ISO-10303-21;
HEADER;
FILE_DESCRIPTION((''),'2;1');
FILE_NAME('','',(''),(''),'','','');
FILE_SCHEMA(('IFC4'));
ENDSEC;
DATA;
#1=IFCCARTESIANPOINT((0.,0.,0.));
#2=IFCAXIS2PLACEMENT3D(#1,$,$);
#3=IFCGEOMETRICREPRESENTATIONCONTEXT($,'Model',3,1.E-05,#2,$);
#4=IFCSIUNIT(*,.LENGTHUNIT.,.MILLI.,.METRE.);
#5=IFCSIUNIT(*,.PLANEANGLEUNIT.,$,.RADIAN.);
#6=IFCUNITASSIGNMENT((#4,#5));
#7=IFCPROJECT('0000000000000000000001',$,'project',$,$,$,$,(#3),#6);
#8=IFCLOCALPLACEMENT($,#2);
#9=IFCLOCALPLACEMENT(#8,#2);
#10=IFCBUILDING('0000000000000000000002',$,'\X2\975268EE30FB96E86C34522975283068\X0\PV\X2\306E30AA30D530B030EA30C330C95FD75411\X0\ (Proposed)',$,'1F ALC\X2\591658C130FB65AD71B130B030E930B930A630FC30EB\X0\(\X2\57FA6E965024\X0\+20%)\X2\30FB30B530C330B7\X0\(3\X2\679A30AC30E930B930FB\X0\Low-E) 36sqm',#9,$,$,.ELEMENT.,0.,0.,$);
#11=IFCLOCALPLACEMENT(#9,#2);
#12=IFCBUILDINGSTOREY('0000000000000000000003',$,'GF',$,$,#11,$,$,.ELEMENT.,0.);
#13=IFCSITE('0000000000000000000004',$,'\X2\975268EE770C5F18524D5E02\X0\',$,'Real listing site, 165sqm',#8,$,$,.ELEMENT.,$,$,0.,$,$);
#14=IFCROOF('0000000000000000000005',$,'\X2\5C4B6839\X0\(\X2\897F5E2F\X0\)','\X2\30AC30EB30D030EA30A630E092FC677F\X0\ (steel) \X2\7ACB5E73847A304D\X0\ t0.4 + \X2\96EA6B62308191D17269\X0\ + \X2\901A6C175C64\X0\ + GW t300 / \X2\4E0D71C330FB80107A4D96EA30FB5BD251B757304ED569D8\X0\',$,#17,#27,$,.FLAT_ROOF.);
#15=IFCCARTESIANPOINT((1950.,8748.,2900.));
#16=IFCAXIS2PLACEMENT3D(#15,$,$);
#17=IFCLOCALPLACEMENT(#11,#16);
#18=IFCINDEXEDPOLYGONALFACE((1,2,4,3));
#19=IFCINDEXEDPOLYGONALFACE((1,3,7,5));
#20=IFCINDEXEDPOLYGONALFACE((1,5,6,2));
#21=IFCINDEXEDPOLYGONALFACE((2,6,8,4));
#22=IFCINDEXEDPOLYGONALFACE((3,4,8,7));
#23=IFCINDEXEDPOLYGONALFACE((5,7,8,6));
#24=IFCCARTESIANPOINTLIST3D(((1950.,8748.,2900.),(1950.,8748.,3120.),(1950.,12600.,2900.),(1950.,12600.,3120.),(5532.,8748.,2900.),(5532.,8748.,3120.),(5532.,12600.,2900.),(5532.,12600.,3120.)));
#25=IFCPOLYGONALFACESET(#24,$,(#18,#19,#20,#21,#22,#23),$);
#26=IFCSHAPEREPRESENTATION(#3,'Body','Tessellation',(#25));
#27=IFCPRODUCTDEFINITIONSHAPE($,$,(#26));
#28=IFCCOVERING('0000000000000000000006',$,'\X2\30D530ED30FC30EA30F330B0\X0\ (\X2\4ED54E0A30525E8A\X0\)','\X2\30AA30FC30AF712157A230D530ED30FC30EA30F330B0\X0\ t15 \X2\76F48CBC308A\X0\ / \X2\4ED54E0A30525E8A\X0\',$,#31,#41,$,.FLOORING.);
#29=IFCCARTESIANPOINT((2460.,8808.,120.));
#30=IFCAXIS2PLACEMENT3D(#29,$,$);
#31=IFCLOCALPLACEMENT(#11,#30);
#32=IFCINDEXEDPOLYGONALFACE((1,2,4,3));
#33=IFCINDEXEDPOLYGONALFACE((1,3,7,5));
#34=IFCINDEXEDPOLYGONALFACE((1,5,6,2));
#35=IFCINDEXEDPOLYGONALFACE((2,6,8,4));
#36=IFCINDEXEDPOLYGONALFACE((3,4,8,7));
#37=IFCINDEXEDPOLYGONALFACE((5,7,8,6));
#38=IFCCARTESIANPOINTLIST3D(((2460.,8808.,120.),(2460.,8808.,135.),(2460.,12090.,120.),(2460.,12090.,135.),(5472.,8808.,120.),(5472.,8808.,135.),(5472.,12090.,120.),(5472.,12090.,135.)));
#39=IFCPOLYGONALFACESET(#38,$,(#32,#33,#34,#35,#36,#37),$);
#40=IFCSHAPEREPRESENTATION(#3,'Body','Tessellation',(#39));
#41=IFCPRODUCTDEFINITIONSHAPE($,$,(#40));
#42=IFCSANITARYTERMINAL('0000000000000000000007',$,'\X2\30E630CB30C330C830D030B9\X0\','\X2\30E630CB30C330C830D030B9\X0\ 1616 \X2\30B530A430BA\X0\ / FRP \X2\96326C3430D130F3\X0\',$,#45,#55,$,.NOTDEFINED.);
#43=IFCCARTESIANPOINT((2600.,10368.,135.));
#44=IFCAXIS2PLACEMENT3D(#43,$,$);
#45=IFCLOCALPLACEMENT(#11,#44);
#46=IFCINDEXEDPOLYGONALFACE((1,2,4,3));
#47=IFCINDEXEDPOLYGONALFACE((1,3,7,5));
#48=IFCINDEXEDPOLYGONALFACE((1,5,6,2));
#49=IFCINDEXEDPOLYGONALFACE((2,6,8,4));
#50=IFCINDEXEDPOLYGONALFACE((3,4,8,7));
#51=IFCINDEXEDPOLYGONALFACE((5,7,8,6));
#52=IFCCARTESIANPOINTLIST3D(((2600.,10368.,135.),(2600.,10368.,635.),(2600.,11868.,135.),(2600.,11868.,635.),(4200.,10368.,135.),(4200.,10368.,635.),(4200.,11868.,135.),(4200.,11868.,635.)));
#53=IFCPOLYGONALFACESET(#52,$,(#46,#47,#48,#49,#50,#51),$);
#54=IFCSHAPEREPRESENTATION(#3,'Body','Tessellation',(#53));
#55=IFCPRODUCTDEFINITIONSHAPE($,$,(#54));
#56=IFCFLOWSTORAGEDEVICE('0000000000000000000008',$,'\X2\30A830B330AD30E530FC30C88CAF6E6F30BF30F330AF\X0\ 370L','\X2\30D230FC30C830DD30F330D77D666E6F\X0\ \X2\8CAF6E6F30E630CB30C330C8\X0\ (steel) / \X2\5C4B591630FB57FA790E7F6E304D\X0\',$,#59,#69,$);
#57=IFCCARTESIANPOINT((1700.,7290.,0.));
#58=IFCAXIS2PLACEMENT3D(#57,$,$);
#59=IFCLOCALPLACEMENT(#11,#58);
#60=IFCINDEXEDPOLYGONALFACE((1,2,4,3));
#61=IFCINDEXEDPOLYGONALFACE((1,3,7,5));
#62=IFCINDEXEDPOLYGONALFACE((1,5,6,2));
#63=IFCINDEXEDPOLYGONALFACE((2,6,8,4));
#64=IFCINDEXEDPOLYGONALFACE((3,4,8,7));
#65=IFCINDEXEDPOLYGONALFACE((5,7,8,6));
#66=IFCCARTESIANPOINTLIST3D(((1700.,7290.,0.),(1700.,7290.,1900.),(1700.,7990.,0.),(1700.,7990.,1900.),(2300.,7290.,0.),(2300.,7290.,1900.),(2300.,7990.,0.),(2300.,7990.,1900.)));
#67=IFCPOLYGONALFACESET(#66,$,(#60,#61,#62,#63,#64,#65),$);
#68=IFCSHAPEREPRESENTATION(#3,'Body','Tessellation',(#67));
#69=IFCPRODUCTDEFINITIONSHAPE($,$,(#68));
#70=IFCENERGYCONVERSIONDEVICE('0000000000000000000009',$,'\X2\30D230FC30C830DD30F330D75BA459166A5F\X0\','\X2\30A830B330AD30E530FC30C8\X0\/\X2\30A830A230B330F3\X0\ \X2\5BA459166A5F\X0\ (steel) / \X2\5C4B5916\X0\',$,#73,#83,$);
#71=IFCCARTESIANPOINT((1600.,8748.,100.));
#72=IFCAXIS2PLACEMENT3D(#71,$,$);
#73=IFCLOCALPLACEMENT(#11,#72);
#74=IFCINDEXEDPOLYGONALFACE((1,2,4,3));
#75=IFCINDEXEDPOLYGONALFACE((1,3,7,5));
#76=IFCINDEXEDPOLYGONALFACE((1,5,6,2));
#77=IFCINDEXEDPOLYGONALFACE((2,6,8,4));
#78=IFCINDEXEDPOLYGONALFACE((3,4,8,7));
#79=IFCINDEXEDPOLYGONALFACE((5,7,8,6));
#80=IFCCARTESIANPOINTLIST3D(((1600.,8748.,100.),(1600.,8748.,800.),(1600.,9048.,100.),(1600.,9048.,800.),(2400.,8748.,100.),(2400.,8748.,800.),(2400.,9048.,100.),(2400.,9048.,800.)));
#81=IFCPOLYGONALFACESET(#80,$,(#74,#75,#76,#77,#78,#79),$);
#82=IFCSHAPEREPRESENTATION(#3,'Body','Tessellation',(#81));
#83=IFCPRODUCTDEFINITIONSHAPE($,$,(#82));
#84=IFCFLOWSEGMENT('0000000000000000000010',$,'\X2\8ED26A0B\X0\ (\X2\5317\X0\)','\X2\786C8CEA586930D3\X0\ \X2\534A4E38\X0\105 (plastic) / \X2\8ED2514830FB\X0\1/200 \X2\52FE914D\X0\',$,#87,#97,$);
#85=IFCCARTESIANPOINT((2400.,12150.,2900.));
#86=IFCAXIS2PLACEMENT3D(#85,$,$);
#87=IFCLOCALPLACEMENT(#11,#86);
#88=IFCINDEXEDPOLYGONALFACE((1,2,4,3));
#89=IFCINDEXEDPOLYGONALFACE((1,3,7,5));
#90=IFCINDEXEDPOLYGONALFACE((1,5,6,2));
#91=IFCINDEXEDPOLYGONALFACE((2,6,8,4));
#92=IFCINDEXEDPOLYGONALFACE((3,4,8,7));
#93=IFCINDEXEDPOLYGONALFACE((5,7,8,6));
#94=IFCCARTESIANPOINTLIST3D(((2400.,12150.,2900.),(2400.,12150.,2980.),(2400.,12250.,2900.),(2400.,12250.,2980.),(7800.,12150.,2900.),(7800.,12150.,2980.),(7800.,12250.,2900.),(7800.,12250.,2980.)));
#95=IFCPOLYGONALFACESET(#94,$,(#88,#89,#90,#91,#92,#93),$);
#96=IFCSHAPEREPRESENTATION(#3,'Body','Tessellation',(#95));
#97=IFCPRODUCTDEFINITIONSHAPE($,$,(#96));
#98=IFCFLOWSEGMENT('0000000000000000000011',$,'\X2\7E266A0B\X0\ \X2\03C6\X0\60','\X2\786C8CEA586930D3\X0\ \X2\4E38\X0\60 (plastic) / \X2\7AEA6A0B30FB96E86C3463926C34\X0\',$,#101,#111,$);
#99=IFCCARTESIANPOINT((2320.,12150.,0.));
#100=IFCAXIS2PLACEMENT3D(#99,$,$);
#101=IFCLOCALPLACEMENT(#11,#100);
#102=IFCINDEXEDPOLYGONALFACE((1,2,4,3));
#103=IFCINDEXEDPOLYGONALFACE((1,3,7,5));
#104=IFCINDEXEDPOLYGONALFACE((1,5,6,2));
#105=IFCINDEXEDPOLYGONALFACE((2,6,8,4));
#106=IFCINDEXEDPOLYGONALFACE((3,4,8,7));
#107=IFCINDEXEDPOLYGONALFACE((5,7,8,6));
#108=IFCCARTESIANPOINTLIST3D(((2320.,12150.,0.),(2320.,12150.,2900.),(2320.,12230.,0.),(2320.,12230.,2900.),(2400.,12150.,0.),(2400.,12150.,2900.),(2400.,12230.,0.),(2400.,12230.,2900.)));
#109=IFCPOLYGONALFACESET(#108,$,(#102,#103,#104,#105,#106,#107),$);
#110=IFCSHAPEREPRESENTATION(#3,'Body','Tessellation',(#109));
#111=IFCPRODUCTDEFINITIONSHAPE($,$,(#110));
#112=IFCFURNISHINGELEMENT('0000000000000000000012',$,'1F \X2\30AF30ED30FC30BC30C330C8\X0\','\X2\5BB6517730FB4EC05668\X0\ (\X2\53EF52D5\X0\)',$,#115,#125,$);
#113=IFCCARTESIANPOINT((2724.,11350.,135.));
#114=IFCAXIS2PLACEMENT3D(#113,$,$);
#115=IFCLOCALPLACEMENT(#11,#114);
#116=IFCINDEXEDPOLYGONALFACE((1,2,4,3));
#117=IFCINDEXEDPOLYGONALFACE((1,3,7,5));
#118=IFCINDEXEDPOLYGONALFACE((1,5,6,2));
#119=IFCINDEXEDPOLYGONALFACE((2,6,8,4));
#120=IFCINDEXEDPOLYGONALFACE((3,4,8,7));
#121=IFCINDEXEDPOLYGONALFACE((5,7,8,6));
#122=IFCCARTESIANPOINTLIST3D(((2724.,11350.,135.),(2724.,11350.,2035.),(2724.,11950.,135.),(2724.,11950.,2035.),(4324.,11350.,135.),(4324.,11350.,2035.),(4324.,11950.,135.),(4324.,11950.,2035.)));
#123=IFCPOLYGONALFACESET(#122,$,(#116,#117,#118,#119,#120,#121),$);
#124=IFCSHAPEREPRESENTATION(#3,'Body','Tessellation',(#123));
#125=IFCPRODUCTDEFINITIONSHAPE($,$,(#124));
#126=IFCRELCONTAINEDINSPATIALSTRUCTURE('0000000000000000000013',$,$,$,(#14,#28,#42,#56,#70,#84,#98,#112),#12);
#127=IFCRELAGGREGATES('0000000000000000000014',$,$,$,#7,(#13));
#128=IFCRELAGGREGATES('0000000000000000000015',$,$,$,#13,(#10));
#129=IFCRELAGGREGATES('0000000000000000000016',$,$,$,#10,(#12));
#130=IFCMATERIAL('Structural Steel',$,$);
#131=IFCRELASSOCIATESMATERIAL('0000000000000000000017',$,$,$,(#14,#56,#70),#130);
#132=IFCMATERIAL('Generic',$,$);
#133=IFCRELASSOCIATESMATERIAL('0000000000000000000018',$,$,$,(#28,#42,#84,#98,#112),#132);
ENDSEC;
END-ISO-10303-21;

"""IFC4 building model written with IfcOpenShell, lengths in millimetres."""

from ifc_helpers import new_model, si_unit, frame, frame_2d, origin, place, context, project, spatial, rectangle, extrude, material, element, save


model = new_model("IFC4")

# Units and contexts
model_context = context("Model", 3, precision=1e-05, world=origin())
ifc_project = project(units=[si_unit("LENGTHUNIT", "METRE", prefix="MILLI"), si_unit("PLANEANGLEUNIT", "RADIAN")], contexts=[model_context])

# Site, building, storey
site_placement = place(None, origin())
site = spatial("IfcSite", under=ifc_project, at=site_placement, Name="青森県弘前市", ObjectType="Real listing site, 165sqm", CompositionType="ELEMENT", RefElevation=0.0)
building_placement = place(site_placement, origin())
building = spatial("IfcBuilding", under=site, at=building_placement, Name="青森・雨水利用とPVのオフグリッド志向 (Proposed)", ObjectType="1F ALC外壁・断熱グラスウール(基準値+20%)・サッシ(3枚ガラス・Low-E) 36sqm", CompositionType="ELEMENT", ElevationOfRefHeight=0.0, ElevationOfTerrain=0.0)
storey_placement = place(building_placement, origin())
storey = spatial("IfcBuildingStorey", under=building, at=storey_placement, Name="GF", CompositionType="ELEMENT", Elevation=0.0)

# Roof
ifc_material_1 = material(Name="Structural Steel")
roof_placement = place(storey_placement, frame((1950.0, 8748.0, 2900.0)))
element("IfcRoof", 1, at=roof_placement, inside=storey, material=ifc_material_1, Name="屋根(西帯)", Description="ガルバリウム鋼板 (steel) 立平葺き t0.4 + 雪止め金物 + 通気層 + GW t300 / 不燃・耐積雪・寒冷地仕様", PredefinedType="FLAT_ROOF", context=model_context, shape_type="SweptSolid", body=[
    extrude(rectangle(XDim=3582.0, YDim=3852.0, at=frame_2d((1791.0, 1926.0))), frame((1950.0, 8748.0, 2900.0)), (0.0, 0.0, 1.0), 220.0),
])

# Covering
ifc_material_2 = material(Name="Generic")
covering_placement = place(storey_placement, frame((2460.0, 8808.0, 120.0)))
element("IfcCovering", 2, at=covering_placement, inside=storey, material=ifc_material_2, Name="フローリング (仕上げ床)", Description="オーク無垢フローリング t15 直貼り / 仕上げ床", PredefinedType="FLOORING", context=model_context, shape_type="SweptSolid", body=[
    extrude(rectangle(XDim=3012.0, YDim=3282.0, at=frame_2d((1506.0, 1641.0))), frame((2460.0, 8808.0, 120.0)), (0.0, 0.0, 1.0), 15.0),
])

# Sanitary terminal
sanitary_terminal_placement = place(storey_placement, frame((2600.0, 10368.0, 135.0)))
element("IfcSanitaryTerminal", 3, at=sanitary_terminal_placement, inside=storey, material=ifc_material_2, Name="ユニットバス", Description="ユニットバス 1616 サイズ / FRP 防水パン", PredefinedType="NOTDEFINED", context=model_context, shape_type="SweptSolid", body=[
    extrude(rectangle(XDim=1600.0, YDim=1500.0, at=frame_2d((800.0, 750.0))), frame((2600.0, 10368.0, 135.0)), (0.0, 0.0, 1.0), 500.0),
])

# Flow storage device
flow_storage_device_placement = place(storey_placement, frame((1700.0, 7290.0, 0.0)))
element("IfcFlowStorageDevice", 4, at=flow_storage_device_placement, inside=storey, material=ifc_material_1, Name="エコキュート貯湯タンク 370L", Description="ヒートポンプ給湯 貯湯ユニット (steel) / 屋外・基礎置き", context=model_context, shape_type="SweptSolid", body=[
    extrude(rectangle(XDim=600.0, YDim=700.0, at=frame_2d((300.0, 350.0))), frame((1700.0, 7290.0, 0.0)), (0.0, 0.0, 1.0), 1900.0),
])

# Energy conversion device
energy_conversion_device_placement = place(storey_placement, frame((1600.0, 8748.0, 100.0)))
element("IfcEnergyConversionDevice", 5, at=energy_conversion_device_placement, inside=storey, material=ifc_material_1, Name="ヒートポンプ室外機", Description="エコキュート/エアコン 室外機 (steel) / 屋外", context=model_context, shape_type="SweptSolid", body=[
    extrude(rectangle(XDim=800.0, YDim=300.0, at=frame_2d((400.0, 150.0))), frame((1600.0, 8748.0, 100.0)), (0.0, 0.0, 1.0), 700.0),
])

# Flow segments
flow_segment_1_placement = place(storey_placement, frame((2400.0, 12150.0, 2900.0)))
element("IfcFlowSegment", 6, at=flow_segment_1_placement, inside=storey, material=ifc_material_2, Name="軒樋 (北)", Description="硬質塩ビ 半丸105 (plastic) / 軒先・1/200 勾配", context=model_context, shape_type="SweptSolid", body=[
    extrude(rectangle(XDim=5400.0, YDim=100.0, at=frame_2d((2700.0, 50.0))), frame((2400.0, 12150.0, 2900.0)), (0.0, 0.0, 1.0), 80.0),
])
flow_segment_2_placement = place(storey_placement, frame((2320.0, 12150.0, 0.0)))
element("IfcFlowSegment", 7, at=flow_segment_2_placement, inside=storey, material=ifc_material_2, Name="縦樋 φ60", Description="硬質塩ビ 丸60 (plastic) / 竪樋・雨水排水", context=model_context, shape_type="SweptSolid", body=[
    extrude(rectangle(XDim=80.0, YDim=80.0, at=frame_2d((40.0, 40.0))), frame((2320.0, 12150.0, 0.0)), (0.0, 0.0, 1.0), 2900.0),
])

# Furnishing element
furnishing_placement = place(storey_placement, frame((2724.0, 11350.0, 135.0)))
element("IfcFurnishingElement", 8, at=furnishing_placement, inside=storey, material=ifc_material_2, Name="1F クローゼット", Description="家具・什器 (可動)", context=model_context, shape_type="SweptSolid", body=[
    extrude(rectangle(XDim=1600.0, YDim=600.0, at=frame_2d((800.0, 300.0))), frame((2724.0, 11350.0, 135.0)), (0.0, 0.0, 1.0), 1900.0),
])

save(model, "model.ifc")
